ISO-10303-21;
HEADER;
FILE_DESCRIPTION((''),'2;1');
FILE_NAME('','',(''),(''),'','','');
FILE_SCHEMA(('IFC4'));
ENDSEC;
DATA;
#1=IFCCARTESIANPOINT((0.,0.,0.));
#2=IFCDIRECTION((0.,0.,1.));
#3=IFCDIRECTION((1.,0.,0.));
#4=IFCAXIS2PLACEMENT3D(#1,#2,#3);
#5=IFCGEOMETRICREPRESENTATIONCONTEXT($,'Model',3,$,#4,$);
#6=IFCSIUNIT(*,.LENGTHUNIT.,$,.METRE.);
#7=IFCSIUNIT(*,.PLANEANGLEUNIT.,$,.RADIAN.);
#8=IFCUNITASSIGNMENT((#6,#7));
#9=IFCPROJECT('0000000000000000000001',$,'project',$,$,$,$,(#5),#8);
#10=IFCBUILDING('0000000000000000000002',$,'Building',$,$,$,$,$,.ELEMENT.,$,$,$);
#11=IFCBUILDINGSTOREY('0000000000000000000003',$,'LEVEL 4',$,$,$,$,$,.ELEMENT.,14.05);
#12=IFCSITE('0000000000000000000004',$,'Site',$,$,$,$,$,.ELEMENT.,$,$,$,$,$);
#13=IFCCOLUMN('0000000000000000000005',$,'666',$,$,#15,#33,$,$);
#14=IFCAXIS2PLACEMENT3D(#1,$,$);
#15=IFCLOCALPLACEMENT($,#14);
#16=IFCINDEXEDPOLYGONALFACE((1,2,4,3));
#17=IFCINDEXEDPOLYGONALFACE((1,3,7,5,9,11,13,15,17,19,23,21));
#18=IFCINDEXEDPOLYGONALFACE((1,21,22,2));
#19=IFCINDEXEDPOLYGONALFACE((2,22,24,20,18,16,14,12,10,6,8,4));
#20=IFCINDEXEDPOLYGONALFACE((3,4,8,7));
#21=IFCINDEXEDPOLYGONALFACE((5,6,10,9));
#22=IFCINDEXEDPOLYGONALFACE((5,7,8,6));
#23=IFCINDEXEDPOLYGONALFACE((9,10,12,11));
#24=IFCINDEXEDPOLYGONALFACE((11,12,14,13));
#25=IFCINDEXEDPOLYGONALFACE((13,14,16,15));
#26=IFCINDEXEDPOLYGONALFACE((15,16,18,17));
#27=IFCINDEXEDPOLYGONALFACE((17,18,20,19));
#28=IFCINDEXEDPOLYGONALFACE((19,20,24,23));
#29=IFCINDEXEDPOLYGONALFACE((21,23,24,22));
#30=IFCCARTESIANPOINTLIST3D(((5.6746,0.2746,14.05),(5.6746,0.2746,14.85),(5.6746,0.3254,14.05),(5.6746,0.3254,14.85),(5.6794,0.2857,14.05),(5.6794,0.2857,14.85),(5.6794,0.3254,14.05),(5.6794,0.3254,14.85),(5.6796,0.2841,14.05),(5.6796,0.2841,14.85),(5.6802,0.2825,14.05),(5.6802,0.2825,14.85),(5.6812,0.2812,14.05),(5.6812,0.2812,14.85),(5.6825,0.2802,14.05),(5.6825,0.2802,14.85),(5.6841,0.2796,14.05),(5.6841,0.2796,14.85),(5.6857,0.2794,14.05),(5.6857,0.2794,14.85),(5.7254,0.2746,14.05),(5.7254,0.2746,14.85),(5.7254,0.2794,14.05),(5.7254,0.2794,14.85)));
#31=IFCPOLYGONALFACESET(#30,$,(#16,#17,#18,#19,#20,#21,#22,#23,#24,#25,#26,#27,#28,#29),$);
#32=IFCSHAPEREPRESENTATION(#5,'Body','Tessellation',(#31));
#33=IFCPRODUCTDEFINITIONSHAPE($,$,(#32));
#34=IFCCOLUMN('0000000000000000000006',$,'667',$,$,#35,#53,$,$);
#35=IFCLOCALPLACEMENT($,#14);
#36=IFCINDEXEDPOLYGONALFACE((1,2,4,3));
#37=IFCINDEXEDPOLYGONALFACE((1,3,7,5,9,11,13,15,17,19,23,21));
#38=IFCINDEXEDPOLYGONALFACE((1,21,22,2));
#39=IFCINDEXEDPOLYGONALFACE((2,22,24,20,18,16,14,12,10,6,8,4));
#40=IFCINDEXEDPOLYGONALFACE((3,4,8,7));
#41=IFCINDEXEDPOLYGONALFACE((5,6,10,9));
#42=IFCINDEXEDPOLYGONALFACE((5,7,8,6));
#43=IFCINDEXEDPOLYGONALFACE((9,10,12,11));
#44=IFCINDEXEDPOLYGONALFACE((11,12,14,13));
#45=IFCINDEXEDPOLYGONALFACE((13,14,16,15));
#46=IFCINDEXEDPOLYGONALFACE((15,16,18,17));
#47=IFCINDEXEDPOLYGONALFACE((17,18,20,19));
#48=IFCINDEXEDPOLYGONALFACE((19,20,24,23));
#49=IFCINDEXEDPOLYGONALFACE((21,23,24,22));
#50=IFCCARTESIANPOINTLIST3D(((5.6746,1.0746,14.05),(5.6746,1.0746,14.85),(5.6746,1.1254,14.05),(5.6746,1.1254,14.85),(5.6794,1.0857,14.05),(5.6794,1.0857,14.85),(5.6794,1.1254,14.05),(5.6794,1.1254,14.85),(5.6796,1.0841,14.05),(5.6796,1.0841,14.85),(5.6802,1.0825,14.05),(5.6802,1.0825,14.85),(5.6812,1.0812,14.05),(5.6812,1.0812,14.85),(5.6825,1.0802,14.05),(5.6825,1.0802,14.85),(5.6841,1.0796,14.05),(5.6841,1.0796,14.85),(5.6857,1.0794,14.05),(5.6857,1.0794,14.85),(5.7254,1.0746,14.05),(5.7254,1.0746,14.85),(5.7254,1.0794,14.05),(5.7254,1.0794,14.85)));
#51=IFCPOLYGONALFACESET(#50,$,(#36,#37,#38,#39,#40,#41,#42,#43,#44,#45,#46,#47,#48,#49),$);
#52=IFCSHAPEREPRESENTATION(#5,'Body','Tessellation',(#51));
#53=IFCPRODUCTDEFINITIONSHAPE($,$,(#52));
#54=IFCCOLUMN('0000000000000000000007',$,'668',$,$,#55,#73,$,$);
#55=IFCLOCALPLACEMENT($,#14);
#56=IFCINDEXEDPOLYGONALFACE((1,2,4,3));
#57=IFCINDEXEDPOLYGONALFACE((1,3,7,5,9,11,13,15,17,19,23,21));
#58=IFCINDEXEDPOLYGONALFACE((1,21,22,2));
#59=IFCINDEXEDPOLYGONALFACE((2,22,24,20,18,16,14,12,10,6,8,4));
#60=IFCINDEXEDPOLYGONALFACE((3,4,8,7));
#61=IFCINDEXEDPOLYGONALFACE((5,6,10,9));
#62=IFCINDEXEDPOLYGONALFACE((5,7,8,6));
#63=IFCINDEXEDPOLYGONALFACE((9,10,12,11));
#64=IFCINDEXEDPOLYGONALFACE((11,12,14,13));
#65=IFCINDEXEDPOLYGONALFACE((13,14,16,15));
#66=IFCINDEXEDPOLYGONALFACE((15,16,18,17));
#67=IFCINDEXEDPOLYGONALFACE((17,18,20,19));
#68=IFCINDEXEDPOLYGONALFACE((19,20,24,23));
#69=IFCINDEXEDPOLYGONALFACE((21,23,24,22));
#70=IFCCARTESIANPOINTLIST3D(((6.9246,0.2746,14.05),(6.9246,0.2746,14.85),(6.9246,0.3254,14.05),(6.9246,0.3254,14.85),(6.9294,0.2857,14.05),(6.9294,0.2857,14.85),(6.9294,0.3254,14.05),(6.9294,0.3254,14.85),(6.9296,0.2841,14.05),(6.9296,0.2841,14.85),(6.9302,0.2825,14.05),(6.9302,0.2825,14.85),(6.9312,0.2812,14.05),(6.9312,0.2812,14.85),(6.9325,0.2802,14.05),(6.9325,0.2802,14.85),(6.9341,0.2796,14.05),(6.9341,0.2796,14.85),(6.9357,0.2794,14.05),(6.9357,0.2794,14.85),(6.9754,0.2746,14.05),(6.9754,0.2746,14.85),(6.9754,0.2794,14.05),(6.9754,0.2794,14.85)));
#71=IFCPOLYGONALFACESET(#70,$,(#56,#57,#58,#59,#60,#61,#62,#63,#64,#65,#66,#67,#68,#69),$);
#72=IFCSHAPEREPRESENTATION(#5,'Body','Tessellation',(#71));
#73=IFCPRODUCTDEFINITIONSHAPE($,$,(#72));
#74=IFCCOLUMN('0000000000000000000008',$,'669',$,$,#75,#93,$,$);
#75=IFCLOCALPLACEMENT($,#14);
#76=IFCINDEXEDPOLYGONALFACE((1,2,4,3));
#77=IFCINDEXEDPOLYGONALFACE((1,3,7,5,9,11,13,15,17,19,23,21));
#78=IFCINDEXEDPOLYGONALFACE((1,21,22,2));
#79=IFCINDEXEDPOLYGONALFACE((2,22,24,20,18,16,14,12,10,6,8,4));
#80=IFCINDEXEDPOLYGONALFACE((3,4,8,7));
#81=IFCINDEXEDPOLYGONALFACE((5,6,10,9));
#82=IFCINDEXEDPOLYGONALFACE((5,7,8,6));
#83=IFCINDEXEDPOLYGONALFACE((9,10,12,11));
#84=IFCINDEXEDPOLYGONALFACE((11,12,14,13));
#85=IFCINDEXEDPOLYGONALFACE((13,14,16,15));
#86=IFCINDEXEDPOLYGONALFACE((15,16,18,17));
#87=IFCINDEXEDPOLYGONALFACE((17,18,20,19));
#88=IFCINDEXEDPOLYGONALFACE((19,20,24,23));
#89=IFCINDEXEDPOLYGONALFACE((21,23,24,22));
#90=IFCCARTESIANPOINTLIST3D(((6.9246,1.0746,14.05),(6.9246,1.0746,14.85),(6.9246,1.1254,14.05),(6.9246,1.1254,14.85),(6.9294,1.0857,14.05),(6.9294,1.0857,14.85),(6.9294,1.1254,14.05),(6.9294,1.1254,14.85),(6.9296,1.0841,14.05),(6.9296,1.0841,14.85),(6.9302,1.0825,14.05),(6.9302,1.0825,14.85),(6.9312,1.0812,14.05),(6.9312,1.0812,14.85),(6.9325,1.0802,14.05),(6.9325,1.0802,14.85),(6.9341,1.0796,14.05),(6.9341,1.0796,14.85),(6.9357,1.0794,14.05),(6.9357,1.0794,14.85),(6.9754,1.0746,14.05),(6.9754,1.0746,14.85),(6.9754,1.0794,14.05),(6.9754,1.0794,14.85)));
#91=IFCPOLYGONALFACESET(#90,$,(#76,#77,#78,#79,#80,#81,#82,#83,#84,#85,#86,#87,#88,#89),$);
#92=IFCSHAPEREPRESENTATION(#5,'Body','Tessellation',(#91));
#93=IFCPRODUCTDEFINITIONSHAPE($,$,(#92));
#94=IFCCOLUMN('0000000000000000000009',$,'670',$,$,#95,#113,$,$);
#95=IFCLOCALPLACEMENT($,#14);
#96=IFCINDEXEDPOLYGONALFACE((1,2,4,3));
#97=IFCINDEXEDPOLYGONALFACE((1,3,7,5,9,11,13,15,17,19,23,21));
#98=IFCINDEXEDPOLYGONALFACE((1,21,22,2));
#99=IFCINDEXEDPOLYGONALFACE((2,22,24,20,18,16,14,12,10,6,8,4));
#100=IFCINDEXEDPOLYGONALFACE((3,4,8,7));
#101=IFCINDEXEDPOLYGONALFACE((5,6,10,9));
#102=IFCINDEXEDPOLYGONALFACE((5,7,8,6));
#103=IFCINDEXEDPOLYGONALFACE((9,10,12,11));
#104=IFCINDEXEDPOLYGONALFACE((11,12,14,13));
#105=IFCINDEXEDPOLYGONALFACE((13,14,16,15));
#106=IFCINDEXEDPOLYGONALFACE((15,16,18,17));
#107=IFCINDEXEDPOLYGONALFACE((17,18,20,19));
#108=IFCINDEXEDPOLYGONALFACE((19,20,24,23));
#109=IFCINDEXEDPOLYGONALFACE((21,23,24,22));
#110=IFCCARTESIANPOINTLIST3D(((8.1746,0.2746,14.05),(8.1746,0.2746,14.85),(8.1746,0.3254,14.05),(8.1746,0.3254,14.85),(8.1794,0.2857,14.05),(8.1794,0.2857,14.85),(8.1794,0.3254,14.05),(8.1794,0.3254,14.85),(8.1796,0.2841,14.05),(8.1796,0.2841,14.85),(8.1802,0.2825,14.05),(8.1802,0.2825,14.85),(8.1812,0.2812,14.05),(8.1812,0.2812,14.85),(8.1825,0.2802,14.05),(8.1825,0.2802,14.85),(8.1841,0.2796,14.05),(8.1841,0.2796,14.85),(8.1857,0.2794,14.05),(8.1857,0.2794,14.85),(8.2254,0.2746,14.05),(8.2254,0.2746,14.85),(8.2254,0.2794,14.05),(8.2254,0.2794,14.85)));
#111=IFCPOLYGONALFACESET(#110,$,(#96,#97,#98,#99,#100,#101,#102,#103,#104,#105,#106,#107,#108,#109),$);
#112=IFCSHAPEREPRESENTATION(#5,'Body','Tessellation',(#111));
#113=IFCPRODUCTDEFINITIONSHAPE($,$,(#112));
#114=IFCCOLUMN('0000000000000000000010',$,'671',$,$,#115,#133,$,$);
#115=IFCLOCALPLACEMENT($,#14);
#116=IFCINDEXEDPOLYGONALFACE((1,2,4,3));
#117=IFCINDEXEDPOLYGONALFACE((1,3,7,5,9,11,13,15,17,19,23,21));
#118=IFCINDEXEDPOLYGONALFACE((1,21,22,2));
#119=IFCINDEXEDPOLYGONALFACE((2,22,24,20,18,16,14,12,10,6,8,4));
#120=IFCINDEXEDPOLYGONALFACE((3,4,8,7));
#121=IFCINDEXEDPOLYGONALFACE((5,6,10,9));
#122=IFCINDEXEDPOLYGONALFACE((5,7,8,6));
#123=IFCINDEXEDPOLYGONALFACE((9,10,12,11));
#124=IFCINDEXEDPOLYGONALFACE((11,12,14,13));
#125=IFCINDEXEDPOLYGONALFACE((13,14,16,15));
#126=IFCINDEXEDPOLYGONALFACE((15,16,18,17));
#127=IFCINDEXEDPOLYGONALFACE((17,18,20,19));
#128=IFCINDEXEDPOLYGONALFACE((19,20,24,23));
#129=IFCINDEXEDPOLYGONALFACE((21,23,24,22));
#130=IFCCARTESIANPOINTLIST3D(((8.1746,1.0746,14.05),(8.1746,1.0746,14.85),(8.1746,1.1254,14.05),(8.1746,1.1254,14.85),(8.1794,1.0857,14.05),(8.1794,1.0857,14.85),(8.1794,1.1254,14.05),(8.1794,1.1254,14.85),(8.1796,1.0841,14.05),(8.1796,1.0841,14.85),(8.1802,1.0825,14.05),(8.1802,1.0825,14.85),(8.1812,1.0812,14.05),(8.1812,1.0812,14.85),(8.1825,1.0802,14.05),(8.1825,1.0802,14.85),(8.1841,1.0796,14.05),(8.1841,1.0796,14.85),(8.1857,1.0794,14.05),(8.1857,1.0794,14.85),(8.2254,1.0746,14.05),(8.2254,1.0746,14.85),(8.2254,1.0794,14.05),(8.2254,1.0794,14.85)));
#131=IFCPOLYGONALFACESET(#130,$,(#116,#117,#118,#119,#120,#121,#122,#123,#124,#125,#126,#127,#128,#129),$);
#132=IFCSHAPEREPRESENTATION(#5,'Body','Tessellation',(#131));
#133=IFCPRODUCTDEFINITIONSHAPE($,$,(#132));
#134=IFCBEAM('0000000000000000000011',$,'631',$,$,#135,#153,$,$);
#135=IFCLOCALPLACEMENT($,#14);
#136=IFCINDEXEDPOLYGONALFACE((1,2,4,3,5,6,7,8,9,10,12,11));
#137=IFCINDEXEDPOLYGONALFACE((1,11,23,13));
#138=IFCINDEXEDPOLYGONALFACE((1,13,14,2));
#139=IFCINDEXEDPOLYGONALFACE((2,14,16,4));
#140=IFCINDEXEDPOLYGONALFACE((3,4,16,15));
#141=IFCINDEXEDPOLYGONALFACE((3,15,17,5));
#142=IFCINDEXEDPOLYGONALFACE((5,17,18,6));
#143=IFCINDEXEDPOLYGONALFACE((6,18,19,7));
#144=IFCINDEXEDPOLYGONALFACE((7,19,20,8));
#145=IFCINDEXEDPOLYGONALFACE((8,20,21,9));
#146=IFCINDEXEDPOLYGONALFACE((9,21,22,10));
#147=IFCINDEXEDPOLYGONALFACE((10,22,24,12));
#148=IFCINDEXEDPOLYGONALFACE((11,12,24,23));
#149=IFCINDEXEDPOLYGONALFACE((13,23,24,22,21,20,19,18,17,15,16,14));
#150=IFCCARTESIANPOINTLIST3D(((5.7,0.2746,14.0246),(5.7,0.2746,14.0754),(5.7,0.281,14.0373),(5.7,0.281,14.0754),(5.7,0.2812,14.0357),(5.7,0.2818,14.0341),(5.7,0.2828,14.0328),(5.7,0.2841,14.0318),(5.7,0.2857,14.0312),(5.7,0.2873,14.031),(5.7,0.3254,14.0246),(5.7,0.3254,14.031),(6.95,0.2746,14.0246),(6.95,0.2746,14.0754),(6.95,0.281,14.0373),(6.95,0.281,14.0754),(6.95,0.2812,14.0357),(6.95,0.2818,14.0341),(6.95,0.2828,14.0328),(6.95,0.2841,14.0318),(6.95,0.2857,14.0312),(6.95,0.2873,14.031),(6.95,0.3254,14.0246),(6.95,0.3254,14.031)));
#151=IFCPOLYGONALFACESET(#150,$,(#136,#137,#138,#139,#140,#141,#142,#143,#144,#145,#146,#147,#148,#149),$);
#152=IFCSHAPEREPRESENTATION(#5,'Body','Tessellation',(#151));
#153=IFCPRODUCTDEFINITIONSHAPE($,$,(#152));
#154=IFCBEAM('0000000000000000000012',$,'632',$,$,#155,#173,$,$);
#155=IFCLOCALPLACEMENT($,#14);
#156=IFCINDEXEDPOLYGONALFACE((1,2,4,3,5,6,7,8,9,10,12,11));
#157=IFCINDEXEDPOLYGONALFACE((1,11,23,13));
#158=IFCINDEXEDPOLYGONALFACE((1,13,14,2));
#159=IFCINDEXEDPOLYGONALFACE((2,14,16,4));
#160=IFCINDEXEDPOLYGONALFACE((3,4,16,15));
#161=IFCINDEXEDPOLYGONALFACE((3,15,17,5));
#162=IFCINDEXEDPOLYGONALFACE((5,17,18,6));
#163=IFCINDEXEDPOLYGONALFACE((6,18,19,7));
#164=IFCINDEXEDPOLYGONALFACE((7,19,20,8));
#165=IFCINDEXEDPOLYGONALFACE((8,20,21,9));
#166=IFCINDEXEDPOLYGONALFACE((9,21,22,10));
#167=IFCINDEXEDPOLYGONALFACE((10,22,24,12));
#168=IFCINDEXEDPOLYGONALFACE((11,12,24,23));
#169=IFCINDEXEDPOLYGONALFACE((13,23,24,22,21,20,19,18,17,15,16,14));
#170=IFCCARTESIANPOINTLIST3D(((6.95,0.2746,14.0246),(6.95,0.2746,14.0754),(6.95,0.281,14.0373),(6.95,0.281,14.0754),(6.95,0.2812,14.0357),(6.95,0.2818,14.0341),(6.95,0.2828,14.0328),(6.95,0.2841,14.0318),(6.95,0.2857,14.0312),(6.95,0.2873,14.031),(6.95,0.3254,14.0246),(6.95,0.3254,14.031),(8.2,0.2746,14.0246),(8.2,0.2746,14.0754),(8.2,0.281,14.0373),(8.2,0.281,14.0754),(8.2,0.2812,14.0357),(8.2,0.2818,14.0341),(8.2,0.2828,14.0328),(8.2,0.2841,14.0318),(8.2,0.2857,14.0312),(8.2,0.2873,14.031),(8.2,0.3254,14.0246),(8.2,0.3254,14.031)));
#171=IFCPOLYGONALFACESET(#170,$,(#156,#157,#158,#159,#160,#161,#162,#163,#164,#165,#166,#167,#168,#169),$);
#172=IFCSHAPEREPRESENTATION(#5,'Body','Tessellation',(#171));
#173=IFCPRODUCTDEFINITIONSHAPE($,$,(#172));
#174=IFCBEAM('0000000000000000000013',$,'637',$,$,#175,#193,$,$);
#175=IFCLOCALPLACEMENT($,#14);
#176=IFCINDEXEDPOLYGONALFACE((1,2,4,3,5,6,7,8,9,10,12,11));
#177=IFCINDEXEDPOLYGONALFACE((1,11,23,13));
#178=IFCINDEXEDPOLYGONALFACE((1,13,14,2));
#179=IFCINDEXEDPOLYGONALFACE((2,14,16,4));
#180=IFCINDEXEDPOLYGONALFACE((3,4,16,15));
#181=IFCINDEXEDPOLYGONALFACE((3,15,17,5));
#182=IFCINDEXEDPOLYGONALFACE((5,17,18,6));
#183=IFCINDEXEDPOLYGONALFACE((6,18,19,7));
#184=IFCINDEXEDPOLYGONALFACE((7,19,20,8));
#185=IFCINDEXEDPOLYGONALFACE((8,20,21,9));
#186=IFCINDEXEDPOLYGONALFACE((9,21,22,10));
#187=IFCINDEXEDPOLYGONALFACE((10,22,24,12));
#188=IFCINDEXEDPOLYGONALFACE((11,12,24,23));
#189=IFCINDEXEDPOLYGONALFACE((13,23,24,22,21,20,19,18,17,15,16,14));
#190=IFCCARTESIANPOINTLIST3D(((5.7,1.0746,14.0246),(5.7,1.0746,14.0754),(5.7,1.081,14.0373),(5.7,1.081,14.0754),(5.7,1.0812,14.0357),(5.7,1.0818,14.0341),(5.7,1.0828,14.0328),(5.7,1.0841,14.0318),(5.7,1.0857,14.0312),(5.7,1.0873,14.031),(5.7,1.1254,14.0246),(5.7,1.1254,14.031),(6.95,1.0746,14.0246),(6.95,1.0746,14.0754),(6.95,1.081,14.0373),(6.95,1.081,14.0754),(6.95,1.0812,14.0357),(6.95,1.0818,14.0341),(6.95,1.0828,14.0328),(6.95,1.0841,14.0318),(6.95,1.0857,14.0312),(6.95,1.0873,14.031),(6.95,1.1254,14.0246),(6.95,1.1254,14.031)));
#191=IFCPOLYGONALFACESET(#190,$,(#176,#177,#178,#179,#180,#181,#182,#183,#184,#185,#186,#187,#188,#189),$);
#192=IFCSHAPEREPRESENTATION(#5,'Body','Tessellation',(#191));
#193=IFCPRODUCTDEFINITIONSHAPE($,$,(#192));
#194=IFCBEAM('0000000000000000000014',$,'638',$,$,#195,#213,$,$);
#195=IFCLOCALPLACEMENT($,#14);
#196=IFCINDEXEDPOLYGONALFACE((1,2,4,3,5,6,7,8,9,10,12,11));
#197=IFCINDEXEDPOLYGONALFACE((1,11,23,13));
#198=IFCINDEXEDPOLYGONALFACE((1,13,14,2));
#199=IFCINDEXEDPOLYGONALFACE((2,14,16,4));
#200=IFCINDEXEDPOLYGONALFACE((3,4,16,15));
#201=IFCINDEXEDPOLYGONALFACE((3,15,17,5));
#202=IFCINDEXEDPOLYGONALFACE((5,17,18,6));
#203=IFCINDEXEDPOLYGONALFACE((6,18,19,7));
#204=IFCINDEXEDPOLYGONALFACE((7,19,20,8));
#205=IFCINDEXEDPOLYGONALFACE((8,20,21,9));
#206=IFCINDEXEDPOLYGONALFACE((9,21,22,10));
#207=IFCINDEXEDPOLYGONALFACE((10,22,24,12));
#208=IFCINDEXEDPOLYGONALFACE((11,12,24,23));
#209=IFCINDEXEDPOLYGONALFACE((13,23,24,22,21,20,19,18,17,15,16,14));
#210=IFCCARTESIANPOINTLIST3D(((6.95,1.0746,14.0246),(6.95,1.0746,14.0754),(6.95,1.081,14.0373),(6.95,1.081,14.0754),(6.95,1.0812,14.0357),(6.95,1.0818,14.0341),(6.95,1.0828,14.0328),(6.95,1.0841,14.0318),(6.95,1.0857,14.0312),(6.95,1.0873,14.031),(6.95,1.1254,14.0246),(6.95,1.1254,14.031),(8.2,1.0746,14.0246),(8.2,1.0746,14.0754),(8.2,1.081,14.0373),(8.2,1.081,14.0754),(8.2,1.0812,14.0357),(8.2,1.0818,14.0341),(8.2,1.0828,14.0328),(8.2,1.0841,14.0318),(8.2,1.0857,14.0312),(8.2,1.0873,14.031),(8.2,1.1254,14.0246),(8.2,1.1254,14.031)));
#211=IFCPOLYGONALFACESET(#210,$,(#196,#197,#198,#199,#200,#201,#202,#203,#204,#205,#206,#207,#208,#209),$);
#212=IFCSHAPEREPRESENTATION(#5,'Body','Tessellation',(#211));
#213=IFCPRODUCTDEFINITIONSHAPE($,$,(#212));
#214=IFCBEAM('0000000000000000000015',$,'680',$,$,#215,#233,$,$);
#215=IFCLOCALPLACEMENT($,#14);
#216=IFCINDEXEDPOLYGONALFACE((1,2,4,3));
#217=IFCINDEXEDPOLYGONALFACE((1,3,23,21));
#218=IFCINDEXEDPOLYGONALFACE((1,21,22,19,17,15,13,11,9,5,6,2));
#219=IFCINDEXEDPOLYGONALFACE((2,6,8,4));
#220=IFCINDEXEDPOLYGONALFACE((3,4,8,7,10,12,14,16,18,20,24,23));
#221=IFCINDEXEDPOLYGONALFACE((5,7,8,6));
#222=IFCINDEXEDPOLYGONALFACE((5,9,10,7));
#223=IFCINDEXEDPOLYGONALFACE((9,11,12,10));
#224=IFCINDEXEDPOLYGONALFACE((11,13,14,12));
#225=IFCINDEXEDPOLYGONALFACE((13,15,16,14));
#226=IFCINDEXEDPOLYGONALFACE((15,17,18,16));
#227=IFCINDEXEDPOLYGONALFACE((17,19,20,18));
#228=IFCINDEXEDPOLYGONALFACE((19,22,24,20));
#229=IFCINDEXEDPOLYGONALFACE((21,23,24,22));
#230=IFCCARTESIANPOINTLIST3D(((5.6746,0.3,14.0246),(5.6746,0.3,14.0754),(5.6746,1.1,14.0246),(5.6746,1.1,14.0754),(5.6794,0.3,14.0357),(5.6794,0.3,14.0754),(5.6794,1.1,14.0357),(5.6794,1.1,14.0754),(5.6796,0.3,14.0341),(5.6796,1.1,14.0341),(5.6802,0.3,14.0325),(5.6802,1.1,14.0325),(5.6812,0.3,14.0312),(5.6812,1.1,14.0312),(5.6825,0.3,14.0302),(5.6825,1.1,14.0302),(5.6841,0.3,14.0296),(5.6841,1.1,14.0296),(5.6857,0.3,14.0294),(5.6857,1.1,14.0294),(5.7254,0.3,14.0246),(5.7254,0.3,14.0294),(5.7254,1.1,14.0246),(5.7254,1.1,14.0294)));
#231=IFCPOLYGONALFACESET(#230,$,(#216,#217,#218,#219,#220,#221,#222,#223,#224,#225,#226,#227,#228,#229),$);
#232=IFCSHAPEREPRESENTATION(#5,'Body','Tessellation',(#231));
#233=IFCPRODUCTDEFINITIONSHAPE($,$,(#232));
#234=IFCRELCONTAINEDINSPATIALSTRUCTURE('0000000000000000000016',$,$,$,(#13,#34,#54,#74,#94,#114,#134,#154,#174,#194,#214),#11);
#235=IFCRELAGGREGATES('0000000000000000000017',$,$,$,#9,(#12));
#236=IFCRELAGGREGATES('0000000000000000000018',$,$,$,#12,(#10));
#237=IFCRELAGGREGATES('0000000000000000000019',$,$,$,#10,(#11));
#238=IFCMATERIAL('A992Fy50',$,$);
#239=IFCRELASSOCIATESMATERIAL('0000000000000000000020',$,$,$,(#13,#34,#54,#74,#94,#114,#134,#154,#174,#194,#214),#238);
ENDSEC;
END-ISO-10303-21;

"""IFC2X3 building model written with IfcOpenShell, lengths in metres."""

from ifc_helpers import new_model, si_unit, frame, origin_with_axes, origin_2d_with_axis, place, context, project, spatial, l_section, extrude, material, element, save


model = new_model("IFC2X3")

# Units and contexts
model_context = context("Model", 3, world=origin_with_axes())
ifc_project = project(units=[si_unit("LENGTHUNIT", "METRE"), si_unit("PLANEANGLEUNIT", "RADIAN")], contexts=[model_context])

# Site, building, storey
site = spatial("IfcSite", under=ifc_project, Name="Site", CompositionType="ELEMENT")
building = spatial("IfcBuilding", under=site, Name="Building", CompositionType="ELEMENT")
storey = spatial("IfcBuildingStorey", under=building, Name="LEVEL 4", CompositionType="ELEMENT", Elevation=14.05)

# Columns
ifc_material = material(Name="A992Fy50")
for number, where, z_axis, x_axis, name in (
    (1, (5.7, 0.3, 14.85), (0.0, 0.0, -1.0), (0.0, 1.0, 0.0), "666"),
    (2, (5.7, 1.1, 14.85), (0.0, 0.0, -1.0), (0.0, 1.0, 0.0), "667"),
    (3, (6.95, 0.3, 14.85), (0.0, 0.0, -1.0), (0.0, 1.0, 0.0), "668"),
    (4, (6.95, 1.1, 14.85), (0.0, 0.0, -1.0), (0.0, 1.0, 0.0), "669"),
    (5, (8.2, 0.3, 14.85), (0.0, 0.0, -1.0), (0.0, 1.0, 0.0), "670"),
    (6, (8.2, 1.1, 14.85), (0.0, 0.0, -1.0), (0.0, 1.0, 0.0), "671"),
):
    element("IfcColumn", number, at=place(None, frame(where, z_axis=z_axis, x_axis=x_axis)), inside=storey, material=ifc_material, Name=name, context=model_context, shape_type="SweptSolid", body=[
        extrude(l_section(Depth=0.0508, Width=0.0508, Thickness=0.0048, FilletRadius=0.0063, at=origin_2d_with_axis()), origin_with_axes(), (0.0, 0.0, 1.0), 0.8),
    ])

# Beams
for number, where, z_axis, x_axis, name in (
    (7, (5.7, 0.3, 14.05), (1.0, 0.0, 0.0), (0.0, 1.0, 0.0), "631"),
    (8, (6.95, 0.3, 14.05), (1.0, 0.0, 0.0), (0.0, 1.0, 0.0), "632"),
    (9, (5.7, 1.1, 14.05), (1.0, 0.0, 0.0), (0.0, 1.0, 0.0), "637"),
    (10, (6.95, 1.1, 14.05), (1.0, 0.0, 0.0), (0.0, 1.0, 0.0), "638"),
):
    element("IfcBeam", number, at=place(None, frame(where, z_axis=z_axis, x_axis=x_axis)), inside=storey, material=ifc_material, Name=name, context=model_context, shape_type="SweptSolid", body=[
        extrude(l_section(Depth=0.0508, Width=0.0508, Thickness=0.0063, FilletRadius=0.0063, at=origin_2d_with_axis()), origin_with_axes(), (0.0, 0.0, 1.0), 1.25),
    ])
for number, where, z_axis, x_axis, name in (
    (11, (5.7, 1.1, 14.05), (0.0, -1.0, 0.0), (1.0, 0.0, 0.0), "680"),
):
    element("IfcBeam", number, at=place(None, frame(where, z_axis=z_axis, x_axis=x_axis)), inside=storey, material=ifc_material, Name=name, context=model_context, shape_type="SweptSolid", body=[
        extrude(l_section(Depth=0.0508, Width=0.0508, Thickness=0.0048, FilletRadius=0.0063, at=origin_2d_with_axis()), origin_with_axes(), (0.0, 0.0, 1.0), 0.8),
    ])

save(model, "model.ifc")
